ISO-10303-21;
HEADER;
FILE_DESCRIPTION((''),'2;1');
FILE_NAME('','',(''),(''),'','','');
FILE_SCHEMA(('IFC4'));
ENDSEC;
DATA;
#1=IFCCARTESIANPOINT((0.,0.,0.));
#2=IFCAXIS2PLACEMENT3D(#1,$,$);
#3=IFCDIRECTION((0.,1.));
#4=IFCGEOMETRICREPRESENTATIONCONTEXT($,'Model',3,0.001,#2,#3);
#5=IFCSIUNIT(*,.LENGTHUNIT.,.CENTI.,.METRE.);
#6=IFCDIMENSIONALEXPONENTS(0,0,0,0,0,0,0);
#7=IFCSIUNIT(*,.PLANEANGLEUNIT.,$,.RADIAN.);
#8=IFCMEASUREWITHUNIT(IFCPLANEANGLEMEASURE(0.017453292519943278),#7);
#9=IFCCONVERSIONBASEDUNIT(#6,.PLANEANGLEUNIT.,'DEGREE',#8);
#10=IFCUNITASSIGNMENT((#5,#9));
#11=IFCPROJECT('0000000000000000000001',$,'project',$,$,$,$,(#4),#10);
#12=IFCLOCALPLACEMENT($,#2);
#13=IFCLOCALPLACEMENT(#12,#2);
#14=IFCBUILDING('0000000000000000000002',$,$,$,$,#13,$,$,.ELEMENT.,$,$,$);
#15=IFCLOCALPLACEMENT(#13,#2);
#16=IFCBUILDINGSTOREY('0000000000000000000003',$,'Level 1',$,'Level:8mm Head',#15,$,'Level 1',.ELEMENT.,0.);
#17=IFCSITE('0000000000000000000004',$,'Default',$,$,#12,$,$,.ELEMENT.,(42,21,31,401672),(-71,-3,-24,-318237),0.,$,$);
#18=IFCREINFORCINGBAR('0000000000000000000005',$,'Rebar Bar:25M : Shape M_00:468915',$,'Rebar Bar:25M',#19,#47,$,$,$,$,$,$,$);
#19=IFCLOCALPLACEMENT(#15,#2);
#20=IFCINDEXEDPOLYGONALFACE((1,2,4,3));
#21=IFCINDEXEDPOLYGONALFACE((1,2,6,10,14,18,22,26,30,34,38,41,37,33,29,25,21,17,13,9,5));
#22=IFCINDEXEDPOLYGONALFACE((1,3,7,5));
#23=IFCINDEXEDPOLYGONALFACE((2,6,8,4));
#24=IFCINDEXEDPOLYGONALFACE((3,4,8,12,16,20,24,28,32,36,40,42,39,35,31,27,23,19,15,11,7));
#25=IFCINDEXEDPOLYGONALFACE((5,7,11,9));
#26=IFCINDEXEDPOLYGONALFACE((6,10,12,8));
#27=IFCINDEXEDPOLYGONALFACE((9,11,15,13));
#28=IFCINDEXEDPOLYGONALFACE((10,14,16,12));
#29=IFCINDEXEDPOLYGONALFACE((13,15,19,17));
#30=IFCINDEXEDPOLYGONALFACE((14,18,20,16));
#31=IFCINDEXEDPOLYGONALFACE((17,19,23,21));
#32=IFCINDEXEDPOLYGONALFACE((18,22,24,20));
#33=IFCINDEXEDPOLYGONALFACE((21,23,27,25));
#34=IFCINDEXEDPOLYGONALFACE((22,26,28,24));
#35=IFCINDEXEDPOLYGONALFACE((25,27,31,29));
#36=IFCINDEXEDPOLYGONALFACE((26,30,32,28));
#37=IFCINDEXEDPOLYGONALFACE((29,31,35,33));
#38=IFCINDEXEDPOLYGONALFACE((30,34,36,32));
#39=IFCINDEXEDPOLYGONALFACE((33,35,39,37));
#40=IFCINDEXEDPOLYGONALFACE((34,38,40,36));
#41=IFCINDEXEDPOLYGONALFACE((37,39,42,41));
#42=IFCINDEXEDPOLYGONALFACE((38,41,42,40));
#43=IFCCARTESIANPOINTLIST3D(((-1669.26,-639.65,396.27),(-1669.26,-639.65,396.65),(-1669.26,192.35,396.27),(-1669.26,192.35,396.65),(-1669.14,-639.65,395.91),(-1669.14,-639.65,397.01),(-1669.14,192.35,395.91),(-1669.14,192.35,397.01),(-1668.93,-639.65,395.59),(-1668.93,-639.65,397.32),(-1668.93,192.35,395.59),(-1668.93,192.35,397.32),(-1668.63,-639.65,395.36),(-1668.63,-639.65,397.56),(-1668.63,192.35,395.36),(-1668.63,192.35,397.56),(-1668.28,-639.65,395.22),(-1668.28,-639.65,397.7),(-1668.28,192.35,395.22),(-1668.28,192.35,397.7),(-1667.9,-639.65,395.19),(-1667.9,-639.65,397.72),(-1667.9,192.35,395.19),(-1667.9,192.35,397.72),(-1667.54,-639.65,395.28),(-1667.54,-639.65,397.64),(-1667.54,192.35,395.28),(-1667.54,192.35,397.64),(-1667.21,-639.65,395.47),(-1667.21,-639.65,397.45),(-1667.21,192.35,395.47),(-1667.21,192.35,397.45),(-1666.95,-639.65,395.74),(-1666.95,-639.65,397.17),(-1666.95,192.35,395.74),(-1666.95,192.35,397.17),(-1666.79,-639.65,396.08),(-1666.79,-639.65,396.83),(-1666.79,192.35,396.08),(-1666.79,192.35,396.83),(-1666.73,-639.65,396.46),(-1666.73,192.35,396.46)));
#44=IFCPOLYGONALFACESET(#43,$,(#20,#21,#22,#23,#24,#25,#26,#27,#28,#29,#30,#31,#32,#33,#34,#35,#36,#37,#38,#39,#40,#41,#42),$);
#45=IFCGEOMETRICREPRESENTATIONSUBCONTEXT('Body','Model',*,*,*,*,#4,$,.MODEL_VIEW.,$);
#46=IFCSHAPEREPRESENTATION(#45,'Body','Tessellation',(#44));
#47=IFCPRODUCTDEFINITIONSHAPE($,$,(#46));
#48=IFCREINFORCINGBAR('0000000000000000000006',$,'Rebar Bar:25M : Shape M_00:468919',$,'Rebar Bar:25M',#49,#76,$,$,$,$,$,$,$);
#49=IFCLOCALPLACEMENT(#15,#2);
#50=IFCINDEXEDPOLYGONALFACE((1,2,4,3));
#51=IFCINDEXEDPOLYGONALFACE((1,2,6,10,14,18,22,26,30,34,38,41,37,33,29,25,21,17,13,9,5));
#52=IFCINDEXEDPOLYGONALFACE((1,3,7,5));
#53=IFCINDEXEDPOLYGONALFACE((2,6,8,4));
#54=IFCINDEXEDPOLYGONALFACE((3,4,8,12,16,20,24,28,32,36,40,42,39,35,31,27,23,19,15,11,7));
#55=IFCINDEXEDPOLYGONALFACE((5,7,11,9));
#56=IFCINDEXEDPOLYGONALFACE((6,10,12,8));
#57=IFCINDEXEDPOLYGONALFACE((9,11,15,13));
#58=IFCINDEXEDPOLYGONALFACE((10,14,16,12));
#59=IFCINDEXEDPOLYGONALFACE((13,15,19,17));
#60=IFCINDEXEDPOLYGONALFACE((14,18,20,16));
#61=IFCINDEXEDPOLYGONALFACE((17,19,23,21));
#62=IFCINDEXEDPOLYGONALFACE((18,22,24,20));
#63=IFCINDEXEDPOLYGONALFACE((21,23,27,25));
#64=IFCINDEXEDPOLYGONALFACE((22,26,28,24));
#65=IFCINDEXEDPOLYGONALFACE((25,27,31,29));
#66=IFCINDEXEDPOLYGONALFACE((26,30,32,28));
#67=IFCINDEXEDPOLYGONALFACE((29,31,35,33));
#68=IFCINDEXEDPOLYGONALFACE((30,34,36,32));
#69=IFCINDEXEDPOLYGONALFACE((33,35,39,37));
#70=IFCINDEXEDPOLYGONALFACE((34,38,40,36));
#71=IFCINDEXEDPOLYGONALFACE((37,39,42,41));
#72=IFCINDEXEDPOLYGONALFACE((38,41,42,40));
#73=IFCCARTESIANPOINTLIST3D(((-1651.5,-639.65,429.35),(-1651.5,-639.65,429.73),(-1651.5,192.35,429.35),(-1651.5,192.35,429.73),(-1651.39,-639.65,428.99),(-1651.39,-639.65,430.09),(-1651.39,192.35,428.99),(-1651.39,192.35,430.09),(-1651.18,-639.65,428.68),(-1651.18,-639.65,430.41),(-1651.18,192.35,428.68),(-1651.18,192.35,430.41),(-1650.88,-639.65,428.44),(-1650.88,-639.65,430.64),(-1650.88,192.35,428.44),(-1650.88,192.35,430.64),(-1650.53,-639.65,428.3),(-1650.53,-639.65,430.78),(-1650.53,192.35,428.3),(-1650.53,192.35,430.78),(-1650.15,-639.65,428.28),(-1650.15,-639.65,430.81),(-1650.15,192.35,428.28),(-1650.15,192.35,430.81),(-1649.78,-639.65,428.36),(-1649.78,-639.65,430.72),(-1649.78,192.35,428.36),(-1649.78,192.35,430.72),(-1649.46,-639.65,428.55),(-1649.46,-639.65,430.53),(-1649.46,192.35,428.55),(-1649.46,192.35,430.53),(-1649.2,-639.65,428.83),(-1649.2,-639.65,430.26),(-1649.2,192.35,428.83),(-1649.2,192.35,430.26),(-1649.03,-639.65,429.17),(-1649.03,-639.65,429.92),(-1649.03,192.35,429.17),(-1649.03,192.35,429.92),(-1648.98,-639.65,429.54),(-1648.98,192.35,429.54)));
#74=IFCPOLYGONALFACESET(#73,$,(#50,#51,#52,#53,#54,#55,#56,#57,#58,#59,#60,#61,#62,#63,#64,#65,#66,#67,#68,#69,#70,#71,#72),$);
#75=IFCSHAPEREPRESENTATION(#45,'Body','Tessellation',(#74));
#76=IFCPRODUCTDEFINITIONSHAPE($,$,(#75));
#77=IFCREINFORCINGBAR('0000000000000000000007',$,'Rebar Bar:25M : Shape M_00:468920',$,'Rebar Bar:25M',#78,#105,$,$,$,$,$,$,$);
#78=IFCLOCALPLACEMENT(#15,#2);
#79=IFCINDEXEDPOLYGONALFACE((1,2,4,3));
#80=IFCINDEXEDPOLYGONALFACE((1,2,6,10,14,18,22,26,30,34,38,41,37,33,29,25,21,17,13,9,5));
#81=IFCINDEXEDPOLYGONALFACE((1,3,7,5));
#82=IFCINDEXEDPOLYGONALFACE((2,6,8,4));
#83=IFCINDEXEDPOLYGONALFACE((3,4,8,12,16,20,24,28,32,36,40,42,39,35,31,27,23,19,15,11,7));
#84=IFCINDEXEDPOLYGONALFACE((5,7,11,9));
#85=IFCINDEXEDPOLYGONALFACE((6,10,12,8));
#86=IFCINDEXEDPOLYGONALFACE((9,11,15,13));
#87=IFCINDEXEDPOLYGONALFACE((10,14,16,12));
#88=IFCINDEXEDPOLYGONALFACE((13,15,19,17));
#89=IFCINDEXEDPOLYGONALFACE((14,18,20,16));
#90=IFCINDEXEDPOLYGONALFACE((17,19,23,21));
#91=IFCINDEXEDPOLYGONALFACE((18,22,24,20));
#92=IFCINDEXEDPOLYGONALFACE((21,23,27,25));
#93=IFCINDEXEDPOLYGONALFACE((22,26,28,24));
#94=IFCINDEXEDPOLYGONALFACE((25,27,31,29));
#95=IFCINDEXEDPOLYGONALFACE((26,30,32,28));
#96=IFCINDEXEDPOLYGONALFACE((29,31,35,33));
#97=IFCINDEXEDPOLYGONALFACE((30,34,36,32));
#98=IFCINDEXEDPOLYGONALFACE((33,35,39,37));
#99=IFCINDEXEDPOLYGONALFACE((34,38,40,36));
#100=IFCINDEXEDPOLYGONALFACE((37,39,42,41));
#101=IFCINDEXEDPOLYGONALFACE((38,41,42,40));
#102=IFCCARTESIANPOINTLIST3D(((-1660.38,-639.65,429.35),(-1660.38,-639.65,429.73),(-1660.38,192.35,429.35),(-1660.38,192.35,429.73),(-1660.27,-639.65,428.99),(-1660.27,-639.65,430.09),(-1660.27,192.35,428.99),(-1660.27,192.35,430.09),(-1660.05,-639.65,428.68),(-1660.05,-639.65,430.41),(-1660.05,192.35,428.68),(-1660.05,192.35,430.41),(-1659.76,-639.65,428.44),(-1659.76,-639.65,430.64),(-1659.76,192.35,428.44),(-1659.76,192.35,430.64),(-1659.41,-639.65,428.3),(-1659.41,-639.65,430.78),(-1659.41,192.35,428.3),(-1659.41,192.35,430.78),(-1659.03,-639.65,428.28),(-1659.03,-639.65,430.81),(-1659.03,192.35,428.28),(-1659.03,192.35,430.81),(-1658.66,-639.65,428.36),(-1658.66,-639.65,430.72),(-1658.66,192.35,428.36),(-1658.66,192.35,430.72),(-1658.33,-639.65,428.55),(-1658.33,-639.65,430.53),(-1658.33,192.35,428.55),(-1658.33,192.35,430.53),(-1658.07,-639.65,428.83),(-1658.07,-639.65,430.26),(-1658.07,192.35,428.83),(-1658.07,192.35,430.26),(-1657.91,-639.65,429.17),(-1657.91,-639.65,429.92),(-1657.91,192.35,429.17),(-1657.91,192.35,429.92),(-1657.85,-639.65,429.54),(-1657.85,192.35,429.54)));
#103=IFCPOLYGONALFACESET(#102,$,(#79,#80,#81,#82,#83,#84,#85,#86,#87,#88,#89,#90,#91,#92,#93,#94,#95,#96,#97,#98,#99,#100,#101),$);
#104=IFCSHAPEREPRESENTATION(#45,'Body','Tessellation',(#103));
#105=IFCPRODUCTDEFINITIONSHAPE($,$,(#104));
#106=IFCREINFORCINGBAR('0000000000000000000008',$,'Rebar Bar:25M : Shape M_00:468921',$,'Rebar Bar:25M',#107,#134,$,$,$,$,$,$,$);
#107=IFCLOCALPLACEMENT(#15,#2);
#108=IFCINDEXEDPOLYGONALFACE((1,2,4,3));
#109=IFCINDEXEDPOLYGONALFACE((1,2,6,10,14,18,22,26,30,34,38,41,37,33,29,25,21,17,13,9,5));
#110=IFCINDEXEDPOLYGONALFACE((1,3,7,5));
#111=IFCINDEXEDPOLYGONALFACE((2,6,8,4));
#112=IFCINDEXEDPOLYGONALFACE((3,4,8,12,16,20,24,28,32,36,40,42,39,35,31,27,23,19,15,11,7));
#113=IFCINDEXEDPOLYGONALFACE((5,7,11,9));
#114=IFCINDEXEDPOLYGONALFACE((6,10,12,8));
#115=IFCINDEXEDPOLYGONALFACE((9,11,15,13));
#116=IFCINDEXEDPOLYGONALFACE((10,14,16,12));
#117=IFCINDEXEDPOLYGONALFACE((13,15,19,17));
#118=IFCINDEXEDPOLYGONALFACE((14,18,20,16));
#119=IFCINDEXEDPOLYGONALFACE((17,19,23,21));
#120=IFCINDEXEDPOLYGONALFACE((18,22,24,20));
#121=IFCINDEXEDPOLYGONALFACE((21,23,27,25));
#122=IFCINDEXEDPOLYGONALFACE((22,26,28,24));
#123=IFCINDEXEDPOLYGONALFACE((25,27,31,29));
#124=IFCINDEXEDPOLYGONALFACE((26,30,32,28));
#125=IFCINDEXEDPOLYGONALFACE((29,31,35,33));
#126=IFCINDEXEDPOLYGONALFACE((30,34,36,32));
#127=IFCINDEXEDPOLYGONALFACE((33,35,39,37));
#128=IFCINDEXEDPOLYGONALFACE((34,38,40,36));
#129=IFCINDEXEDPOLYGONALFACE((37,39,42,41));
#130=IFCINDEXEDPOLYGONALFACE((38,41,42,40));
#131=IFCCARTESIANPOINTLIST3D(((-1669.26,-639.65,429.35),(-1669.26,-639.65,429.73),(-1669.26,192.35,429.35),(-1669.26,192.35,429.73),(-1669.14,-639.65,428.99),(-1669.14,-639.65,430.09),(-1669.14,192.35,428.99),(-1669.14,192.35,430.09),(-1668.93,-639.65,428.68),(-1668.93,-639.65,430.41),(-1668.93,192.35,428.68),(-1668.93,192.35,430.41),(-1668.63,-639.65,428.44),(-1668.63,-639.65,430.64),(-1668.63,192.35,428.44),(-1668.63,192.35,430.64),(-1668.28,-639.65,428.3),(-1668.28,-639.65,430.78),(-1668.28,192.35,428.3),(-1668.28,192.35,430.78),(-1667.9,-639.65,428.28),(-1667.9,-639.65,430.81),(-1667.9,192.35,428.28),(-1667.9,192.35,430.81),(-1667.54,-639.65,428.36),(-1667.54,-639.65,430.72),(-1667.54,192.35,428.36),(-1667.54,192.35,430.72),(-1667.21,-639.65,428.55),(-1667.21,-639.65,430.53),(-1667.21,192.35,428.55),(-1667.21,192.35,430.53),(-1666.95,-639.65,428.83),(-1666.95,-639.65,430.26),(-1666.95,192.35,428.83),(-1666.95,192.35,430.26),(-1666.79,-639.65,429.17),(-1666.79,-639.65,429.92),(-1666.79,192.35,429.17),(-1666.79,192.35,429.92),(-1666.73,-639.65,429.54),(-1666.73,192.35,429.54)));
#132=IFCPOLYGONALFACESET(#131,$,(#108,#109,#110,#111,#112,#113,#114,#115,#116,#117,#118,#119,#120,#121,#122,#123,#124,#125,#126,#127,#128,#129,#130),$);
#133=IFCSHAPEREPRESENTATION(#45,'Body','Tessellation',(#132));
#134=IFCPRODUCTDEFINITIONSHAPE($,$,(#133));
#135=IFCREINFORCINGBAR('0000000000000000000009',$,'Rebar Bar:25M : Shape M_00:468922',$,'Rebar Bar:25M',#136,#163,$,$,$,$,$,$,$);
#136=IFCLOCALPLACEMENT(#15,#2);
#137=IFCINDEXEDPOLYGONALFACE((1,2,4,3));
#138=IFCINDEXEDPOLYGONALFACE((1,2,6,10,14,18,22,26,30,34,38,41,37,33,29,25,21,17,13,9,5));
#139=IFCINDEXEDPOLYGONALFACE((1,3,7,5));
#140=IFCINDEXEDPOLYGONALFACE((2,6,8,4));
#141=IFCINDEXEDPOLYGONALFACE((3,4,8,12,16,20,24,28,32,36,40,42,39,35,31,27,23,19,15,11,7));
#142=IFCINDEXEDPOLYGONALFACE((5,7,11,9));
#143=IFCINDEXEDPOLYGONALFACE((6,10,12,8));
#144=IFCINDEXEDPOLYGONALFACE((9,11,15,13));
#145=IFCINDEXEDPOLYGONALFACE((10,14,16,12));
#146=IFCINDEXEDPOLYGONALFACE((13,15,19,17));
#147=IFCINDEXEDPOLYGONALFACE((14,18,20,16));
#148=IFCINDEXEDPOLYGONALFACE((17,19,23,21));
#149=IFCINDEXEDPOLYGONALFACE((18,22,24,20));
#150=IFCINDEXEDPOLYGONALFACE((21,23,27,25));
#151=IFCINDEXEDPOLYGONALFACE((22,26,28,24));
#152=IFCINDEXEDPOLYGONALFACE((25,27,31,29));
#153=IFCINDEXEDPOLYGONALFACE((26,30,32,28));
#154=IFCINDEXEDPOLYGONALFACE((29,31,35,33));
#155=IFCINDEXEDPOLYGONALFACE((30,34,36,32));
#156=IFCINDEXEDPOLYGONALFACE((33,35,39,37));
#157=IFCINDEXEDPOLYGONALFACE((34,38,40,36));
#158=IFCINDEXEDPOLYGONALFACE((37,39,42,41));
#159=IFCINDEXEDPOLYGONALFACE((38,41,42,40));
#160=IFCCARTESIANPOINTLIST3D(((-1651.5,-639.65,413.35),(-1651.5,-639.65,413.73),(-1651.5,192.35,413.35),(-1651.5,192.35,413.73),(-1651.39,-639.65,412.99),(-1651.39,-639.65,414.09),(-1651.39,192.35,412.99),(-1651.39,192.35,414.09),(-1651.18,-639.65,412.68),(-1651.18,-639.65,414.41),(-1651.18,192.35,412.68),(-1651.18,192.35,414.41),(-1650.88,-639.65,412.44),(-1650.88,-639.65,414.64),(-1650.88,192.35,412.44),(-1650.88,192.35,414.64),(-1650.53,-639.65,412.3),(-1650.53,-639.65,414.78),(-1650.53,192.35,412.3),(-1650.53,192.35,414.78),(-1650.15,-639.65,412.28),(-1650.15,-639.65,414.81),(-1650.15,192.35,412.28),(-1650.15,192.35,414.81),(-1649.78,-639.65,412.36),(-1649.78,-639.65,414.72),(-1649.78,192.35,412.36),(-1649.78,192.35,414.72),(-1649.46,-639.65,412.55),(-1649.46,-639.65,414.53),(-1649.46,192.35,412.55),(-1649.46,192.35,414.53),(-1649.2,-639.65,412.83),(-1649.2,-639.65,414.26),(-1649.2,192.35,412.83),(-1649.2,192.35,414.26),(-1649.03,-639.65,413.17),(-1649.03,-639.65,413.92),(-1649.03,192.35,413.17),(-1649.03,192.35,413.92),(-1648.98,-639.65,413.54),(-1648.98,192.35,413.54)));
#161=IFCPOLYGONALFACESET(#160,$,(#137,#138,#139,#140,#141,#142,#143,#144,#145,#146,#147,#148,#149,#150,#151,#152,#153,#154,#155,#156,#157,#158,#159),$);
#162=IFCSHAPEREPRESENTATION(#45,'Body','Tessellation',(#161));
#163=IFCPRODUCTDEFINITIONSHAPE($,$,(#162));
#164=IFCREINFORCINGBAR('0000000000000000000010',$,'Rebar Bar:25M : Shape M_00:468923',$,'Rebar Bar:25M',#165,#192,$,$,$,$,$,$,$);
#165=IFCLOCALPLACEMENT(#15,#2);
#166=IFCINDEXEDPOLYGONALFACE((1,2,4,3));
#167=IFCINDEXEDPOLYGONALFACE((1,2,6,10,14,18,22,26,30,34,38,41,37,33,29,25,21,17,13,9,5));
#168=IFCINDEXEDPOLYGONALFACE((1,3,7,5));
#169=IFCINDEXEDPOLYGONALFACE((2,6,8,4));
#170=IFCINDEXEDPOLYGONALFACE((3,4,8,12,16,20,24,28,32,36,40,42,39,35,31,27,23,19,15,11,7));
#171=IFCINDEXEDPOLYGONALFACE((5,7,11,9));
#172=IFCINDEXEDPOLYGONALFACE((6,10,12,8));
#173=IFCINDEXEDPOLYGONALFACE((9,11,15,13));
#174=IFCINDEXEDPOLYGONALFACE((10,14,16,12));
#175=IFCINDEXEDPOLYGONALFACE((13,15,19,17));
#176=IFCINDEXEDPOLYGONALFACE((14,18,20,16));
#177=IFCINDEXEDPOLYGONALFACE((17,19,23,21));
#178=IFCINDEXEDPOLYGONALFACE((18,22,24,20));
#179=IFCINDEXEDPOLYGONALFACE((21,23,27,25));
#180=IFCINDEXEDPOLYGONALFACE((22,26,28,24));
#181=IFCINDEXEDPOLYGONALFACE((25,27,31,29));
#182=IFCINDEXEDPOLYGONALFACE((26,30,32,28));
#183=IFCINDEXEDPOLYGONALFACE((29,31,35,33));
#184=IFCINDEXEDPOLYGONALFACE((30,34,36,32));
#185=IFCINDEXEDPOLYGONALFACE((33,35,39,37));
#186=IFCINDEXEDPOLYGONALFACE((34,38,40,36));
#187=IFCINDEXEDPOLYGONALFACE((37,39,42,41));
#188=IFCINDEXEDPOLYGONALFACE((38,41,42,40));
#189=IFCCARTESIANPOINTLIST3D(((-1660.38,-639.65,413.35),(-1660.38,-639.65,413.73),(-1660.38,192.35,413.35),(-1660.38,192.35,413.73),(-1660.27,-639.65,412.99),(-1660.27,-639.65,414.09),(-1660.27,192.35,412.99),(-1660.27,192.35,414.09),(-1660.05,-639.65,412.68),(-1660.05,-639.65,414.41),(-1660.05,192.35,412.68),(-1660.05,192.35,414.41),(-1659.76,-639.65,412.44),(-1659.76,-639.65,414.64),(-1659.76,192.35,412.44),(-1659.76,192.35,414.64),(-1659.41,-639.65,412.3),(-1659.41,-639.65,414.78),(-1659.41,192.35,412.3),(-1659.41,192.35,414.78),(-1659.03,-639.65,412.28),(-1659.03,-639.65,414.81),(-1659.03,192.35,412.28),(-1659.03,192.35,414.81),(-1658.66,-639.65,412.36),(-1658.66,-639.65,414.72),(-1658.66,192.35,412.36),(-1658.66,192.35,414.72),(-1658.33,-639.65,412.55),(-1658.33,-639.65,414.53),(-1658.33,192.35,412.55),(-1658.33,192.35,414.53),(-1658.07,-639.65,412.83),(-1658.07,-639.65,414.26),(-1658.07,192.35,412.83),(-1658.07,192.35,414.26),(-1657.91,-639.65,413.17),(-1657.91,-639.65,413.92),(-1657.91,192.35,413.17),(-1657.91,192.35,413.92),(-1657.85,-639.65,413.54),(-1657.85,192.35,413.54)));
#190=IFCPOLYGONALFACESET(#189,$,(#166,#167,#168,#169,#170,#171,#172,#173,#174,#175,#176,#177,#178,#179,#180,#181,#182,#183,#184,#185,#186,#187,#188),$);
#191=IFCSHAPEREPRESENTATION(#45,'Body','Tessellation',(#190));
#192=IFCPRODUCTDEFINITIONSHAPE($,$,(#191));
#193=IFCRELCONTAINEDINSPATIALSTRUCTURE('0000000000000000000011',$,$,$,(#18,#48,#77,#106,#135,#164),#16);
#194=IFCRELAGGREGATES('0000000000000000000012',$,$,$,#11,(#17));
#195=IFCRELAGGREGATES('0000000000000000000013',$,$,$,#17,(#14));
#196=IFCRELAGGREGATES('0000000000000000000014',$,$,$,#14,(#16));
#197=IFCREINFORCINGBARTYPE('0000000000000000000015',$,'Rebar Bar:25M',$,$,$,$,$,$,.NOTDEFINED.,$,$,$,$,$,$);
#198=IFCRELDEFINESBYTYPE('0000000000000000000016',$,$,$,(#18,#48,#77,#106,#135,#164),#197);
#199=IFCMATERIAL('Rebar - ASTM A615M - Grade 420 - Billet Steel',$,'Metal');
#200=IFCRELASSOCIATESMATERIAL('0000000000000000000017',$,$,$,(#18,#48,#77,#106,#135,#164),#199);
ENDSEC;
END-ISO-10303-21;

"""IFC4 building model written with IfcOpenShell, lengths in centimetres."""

from ifc_helpers import new_model, entity, si_unit, converted_unit, direction, origin, place, context, subcontext, project, spatial, material, type_object, element, save


model = new_model("IFC4")

# Units and contexts
model_context = context("Model", 3, precision=0.001, world=origin(), true_north=direction((0.0, 1.0)))
body_context = subcontext(model_context, "Body", "Model", "MODEL_VIEW")
ifc_project = project(units=[si_unit("LENGTHUNIT", "METRE", prefix="CENTI"), converted_unit("PLANEANGLEUNIT", "DEGREE", entity("IfcPlaneAngleMeasure", 0.017453292519943278), si_unit("PLANEANGLEUNIT", "RADIAN"), dimensions=[0, 0, 0, 0, 0, 0, 0])], contexts=[model_context])

# Site, building, storey
site_placement = place(None, origin())
site = spatial("IfcSite", under=ifc_project, at=site_placement, Name="Default", CompositionType="ELEMENT", RefLatitude=(42, 21, 31, 401672), RefLongitude=(-71, -3, -24, -318237), RefElevation=0.0)
building_placement = place(site_placement, origin())
building = spatial("IfcBuilding", under=site, at=building_placement, CompositionType="ELEMENT")
storey_placement = place(building_placement, origin())
storey = spatial("IfcBuildingStorey", under=building, at=storey_placement, Name="Level 1", ObjectType="Level:8mm Head", LongName="Level 1", CompositionType="ELEMENT", Elevation=0.0)

# Reinforcing bars
ifc_material_1 = material(Name="Rebar - ASTM A615M - Grade 420 - Billet Steel", Category="Metal")
reinforcing_bar_type_1 = type_object("IfcReinforcingBarType", Name="Rebar Bar:25M", PredefinedType="NOTDEFINED")
reinforcing_bar_1_placement = place(storey_placement, origin())
element("IfcReinforcingBar", 1, at=reinforcing_bar_1_placement, inside=storey, type_object=reinforcing_bar_type_1, material=ifc_material_1, Name="Rebar Bar:25M : Shape M_00:468915", ObjectType="Rebar Bar:25M", context=body_context, shape_type="AdvancedSweptSolid", body=[
    entity("IfcSweptDiskSolid", entity("IfcIndexedPolyCurve", entity("IfcCartesianPointList3D", [[-1668.0, -639.65, 396.46], [-1668.0, 192.35, 396.46]]), None, False), 1.27, None, 0.0, 1.0),
])
reinforcing_bar_2_placement = place(storey_placement, origin())
element("IfcReinforcingBar", 2, at=reinforcing_bar_2_placement, inside=storey, type_object=reinforcing_bar_type_1, material=ifc_material_1, Name="Rebar Bar:25M : Shape M_00:468919", ObjectType="Rebar Bar:25M", context=body_context, shape_type="AdvancedSweptSolid", body=[
    entity("IfcSweptDiskSolid", entity("IfcIndexedPolyCurve", entity("IfcCartesianPointList3D", [[-1650.25, -639.65, 429.54], [-1650.25, 192.35, 429.54]]), None, False), 1.27, None, 0.0, 1.0),
])
reinforcing_bar_3_placement = place(storey_placement, origin())
element("IfcReinforcingBar", 3, at=reinforcing_bar_3_placement, inside=storey, type_object=reinforcing_bar_type_1, material=ifc_material_1, Name="Rebar Bar:25M : Shape M_00:468920", ObjectType="Rebar Bar:25M", context=body_context, shape_type="AdvancedSweptSolid", body=[
    entity("IfcSweptDiskSolid", entity("IfcIndexedPolyCurve", entity("IfcCartesianPointList3D", [[-1659.12, -639.65, 429.54], [-1659.12, 192.35, 429.54]]), None, False), 1.27, None, 0.0, 1.0),
])
reinforcing_bar_4_placement = place(storey_placement, origin())
element("IfcReinforcingBar", 4, at=reinforcing_bar_4_placement, inside=storey, type_object=reinforcing_bar_type_1, material=ifc_material_1, Name="Rebar Bar:25M : Shape M_00:468921", ObjectType="Rebar Bar:25M", context=body_context, shape_type="AdvancedSweptSolid", body=[
    entity("IfcSweptDiskSolid", entity("IfcIndexedPolyCurve", entity("IfcCartesianPointList3D", [[-1668.0, -639.65, 429.54], [-1668.0, 192.35, 429.54]]), None, False), 1.27, None, 0.0, 1.0),
])
reinforcing_bar_5_placement = place(storey_placement, origin())
element("IfcReinforcingBar", 5, at=reinforcing_bar_5_placement, inside=storey, type_object=reinforcing_bar_type_1, material=ifc_material_1, Name="Rebar Bar:25M : Shape M_00:468922", ObjectType="Rebar Bar:25M", context=body_context, shape_type="AdvancedSweptSolid", body=[
    entity("IfcSweptDiskSolid", entity("IfcIndexedPolyCurve", entity("IfcCartesianPointList3D", [[-1650.25, -639.65, 413.54], [-1650.25, 192.35, 413.54]]), None, False), 1.27, None, 0.0, 1.0),
])
reinforcing_bar_6_placement = place(storey_placement, origin())
element("IfcReinforcingBar", 6, at=reinforcing_bar_6_placement, inside=storey, type_object=reinforcing_bar_type_1, material=ifc_material_1, Name="Rebar Bar:25M : Shape M_00:468923", ObjectType="Rebar Bar:25M", context=body_context, shape_type="AdvancedSweptSolid", body=[
    entity("IfcSweptDiskSolid", entity("IfcIndexedPolyCurve", entity("IfcCartesianPointList3D", [[-1659.12, -639.65, 413.54], [-1659.12, 192.35, 413.54]]), None, False), 1.27, None, 0.0, 1.0),
])

save(model, "model.ifc")
